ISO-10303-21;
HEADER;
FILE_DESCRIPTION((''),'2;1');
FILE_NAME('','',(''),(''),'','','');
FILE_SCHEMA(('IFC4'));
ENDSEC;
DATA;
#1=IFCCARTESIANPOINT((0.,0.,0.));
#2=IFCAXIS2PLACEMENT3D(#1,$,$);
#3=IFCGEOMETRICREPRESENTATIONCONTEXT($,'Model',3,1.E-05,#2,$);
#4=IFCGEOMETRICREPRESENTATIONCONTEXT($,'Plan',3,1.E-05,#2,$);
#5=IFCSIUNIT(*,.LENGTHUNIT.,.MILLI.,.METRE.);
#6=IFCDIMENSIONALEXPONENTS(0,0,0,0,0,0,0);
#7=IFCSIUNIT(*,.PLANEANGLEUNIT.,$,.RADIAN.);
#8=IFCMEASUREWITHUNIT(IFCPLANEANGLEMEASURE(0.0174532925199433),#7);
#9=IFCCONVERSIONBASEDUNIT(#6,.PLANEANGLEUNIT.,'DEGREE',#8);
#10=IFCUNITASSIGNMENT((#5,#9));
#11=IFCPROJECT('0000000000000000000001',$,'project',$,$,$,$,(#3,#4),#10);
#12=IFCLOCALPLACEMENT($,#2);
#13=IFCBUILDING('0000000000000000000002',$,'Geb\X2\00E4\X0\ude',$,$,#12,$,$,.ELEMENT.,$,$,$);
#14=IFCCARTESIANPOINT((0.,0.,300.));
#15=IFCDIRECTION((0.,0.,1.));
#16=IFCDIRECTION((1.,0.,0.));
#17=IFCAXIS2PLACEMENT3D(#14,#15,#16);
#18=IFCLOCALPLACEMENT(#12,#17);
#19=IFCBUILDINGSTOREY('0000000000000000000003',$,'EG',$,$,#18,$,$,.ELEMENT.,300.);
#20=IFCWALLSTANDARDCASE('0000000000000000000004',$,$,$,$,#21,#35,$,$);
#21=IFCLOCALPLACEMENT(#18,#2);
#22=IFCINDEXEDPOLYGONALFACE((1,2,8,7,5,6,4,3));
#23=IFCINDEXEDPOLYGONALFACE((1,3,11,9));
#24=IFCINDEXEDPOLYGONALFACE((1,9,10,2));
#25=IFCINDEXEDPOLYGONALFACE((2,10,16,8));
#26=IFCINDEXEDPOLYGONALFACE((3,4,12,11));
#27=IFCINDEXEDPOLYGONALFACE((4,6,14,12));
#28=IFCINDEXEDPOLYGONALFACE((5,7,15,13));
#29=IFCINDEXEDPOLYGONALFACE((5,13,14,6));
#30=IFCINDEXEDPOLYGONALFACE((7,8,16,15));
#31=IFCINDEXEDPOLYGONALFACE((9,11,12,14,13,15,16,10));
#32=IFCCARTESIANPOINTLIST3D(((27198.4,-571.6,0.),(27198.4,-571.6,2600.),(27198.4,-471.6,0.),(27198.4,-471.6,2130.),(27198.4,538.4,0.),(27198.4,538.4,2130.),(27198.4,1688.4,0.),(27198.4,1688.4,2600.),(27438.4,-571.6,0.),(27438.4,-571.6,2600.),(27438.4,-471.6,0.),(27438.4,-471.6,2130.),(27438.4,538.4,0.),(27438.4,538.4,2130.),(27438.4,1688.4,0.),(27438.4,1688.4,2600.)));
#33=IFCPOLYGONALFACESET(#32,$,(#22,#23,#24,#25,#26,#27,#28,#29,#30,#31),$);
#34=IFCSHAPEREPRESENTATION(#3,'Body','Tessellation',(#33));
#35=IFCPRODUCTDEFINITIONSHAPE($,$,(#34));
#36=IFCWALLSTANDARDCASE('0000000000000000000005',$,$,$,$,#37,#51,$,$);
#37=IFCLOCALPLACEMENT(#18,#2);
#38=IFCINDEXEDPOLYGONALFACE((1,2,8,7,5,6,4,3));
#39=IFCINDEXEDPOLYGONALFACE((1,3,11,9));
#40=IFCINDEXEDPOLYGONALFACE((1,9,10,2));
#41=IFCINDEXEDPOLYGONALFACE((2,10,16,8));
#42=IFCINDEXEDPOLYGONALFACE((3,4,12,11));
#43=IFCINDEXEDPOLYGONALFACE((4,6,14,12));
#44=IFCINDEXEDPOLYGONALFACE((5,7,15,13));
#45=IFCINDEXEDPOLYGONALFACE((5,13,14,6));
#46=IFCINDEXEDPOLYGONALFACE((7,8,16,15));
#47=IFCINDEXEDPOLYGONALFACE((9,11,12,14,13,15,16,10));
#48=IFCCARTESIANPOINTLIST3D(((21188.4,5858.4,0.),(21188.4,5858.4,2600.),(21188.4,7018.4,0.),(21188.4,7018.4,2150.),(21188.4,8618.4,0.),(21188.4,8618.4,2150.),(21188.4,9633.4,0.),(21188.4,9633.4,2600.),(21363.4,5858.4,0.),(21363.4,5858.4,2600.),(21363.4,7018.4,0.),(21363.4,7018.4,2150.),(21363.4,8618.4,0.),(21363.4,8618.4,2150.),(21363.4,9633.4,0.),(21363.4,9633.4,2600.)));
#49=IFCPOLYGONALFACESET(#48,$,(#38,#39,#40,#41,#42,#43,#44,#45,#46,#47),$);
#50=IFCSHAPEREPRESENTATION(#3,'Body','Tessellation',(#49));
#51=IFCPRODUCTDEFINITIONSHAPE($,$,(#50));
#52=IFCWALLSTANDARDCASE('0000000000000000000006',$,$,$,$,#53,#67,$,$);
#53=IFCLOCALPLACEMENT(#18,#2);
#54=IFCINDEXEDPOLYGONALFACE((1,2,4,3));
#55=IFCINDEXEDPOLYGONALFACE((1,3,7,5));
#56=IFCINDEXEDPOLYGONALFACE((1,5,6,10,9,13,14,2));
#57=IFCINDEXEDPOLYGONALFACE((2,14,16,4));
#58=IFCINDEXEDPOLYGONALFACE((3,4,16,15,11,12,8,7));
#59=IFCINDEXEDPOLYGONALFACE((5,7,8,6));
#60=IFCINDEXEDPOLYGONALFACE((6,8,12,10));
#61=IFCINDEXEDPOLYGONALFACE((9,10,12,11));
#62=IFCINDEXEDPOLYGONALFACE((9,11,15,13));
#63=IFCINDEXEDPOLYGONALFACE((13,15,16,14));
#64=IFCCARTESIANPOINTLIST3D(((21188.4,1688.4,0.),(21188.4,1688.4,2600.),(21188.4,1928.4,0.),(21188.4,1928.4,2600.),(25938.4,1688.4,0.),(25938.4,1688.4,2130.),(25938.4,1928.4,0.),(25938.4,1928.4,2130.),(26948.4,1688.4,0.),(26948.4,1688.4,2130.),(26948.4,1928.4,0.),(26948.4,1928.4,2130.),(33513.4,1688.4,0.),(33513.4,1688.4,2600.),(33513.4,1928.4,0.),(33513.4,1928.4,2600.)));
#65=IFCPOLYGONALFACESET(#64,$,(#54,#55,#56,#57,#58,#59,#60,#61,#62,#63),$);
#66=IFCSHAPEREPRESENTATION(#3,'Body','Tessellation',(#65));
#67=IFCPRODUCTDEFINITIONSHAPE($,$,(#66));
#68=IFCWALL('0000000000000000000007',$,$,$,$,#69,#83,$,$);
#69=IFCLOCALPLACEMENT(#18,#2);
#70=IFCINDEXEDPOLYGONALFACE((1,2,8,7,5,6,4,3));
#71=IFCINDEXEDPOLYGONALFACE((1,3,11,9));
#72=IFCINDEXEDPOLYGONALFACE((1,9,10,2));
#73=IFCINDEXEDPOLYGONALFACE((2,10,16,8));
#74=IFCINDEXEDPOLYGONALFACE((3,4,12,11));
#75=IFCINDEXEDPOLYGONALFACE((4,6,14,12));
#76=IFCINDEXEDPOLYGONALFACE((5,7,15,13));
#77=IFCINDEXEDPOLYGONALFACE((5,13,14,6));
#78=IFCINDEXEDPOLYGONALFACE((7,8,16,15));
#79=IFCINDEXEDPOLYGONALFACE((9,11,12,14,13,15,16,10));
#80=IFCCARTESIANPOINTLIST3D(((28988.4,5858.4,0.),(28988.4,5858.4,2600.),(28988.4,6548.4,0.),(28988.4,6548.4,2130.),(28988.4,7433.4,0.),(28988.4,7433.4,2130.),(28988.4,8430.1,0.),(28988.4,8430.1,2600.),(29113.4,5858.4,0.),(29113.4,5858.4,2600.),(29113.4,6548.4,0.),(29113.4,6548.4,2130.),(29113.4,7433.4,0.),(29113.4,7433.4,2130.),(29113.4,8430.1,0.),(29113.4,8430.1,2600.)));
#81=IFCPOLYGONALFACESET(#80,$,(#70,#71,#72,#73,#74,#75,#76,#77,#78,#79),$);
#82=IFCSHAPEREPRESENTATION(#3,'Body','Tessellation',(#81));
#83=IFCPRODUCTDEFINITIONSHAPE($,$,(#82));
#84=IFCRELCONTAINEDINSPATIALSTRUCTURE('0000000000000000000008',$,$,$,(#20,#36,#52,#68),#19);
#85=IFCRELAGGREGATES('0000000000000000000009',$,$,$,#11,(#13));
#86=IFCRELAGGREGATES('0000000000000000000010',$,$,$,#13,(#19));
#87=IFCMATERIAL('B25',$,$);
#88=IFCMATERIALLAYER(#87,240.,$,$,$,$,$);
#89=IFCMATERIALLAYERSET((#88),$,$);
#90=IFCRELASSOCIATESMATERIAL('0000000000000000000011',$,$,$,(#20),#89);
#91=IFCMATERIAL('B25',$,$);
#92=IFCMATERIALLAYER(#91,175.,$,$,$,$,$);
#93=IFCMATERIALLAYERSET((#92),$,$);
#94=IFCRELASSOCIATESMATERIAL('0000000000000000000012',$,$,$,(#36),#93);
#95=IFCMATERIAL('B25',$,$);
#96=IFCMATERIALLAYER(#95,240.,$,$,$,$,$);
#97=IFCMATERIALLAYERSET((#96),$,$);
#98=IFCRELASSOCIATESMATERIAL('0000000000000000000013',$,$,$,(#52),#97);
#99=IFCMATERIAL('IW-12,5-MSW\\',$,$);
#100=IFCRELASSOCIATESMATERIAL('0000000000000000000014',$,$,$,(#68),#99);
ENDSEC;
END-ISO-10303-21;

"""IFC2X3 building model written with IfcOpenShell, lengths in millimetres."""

from ifc_helpers import new_model, entity, si_unit, converted_unit, frame, frame_2d, origin, origin_with_axes, place, context, project, spatial, polyline, rectangle, outline, extrude, material, layer, layer_set, layer_usage, element, save


model = new_model("IFC2X3")

# Units and contexts
model_context = context("Model", 3, precision=1e-05, world=origin())
plan_context = context("Plan", 3, precision=1e-05, world=origin())
ifc_project = project(units=[si_unit("LENGTHUNIT", "METRE", prefix="MILLI"), converted_unit("PLANEANGLEUNIT", "DEGREE", entity("IfcPlaneAngleMeasure", 0.0174532925199433), si_unit("PLANEANGLEUNIT", "RADIAN"), dimensions=[0, 0, 0, 0, 0, 0, 0])], contexts=[model_context, plan_context])

# Building, storey
building_placement = place(None, origin())
building = spatial("IfcBuilding", under=ifc_project, at=building_placement, Name="Gebäude", CompositionType="ELEMENT")
storey_placement = place(building_placement, frame((0.0, 0.0, 300.0), z_axis=(0.0, 0.0, 1.0), x_axis=(1.0, 0.0, 0.0)))
storey = spatial("IfcBuildingStorey", under=building, at=storey_placement, Name="EG", CompositionType="ELEMENT", Elevation=300.0)

# Walls, openings
ifc_material_1 = material(Name="B25")
ifc_layer_1 = layer(ifc_material_1, 240.0)
ifc_layer_set_1 = layer_set([ifc_layer_1])
ifc_layer_usage_1 = layer_usage(ifc_layer_set_1, "AXIS2", "POSITIVE", 0.0)
wall_1_placement = place(storey_placement, frame((27198.4, 1688.4, 0.0), z_axis=(0.0, 0.0, 1.0), x_axis=(0.0, -1.0, 0.0)))
wall_1 = element("IfcWallStandardCase", 1, at=wall_1_placement, inside=storey, material=ifc_layer_usage_1, context=model_context, shape_type="SweptSolid", body=[
    extrude(rectangle(XDim=2260.0, YDim=240.0, at=frame_2d((1130.0, 120.0), x_axis=(1.0, 0.0))), origin_with_axes(), (0.0, 0.0, 1.0), 2600.0),
])
opening_1_placement = place(wall_1_placement, frame((1150.0, 0.0, 0.0), z_axis=(0.0, 1.0, 0.0), x_axis=(0.0, 0.0, 1.0)))
element("IfcOpeningElement", 2, at=opening_1_placement, cuts=wall_1, ObjectType="Opening", context=model_context, shape_type="SweptSolid", body=[
    extrude(rectangle(XDim=2130.0, YDim=1010.0, at=frame_2d((1065.0, 505.0), x_axis=(1.0, 0.0))), origin_with_axes(), (0.0, 0.0, 1.0), 240.0),
])
ifc_material_2 = material(Name="B25")
ifc_layer_2 = layer(ifc_material_2, 175.0)
ifc_layer_set_2 = layer_set([ifc_layer_2])
ifc_layer_usage_2 = layer_usage(ifc_layer_set_2, "AXIS2", "POSITIVE", 0.0)
wall_2_placement = place(storey_placement, frame((21188.4, 9633.4, 0.0), z_axis=(0.0, 0.0, 1.0), x_axis=(0.0, -1.0, 0.0)))
wall_2 = element("IfcWallStandardCase", 3, at=wall_2_placement, inside=storey, material=ifc_layer_usage_2, context=model_context, shape_type="SweptSolid", body=[
    extrude(rectangle(XDim=3775.0, YDim=175.0, at=frame_2d((1887.5, 87.5), x_axis=(1.0, 0.0))), origin_with_axes(), (0.0, 0.0, 1.0), 2600.0),
])
opening_2_placement = place(wall_2_placement, frame((1015.0, 0.0, 0.0), z_axis=(0.0, 1.0, 0.0), x_axis=(0.0, 0.0, 1.0)))
element("IfcOpeningElement", 4, at=opening_2_placement, cuts=wall_2, ObjectType="Opening", context=model_context, shape_type="SweptSolid", body=[
    extrude(rectangle(XDim=2150.0, YDim=1600.0, at=frame_2d((1075.0, 800.0), x_axis=(1.0, 0.0))), origin_with_axes(), (0.0, 0.0, 1.0), 175.0),
])
ifc_material_3 = material(Name="B25")
ifc_layer_3 = layer(ifc_material_3, 240.0)
ifc_layer_set_3 = layer_set([ifc_layer_3])
ifc_layer_usage_3 = layer_usage(ifc_layer_set_3, "AXIS2", "POSITIVE", 0.0)
wall_3_placement = place(storey_placement, frame((33513.4, 1928.4, 0.0), z_axis=(0.0, 0.0, 1.0), x_axis=(-1.0, 0.0, 0.0)))
wall_3 = element("IfcWallStandardCase", 5, at=wall_3_placement, inside=storey, material=ifc_layer_usage_3, context=model_context, shape_type="SweptSolid", body=[
    extrude(rectangle(XDim=12325.0, YDim=240.0, at=frame_2d((6162.5, 120.0), x_axis=(1.0, 0.0))), origin_with_axes(), (0.0, 0.0, 1.0), 2600.0),
])
opening_3_placement = place(wall_3_placement, frame((6565.0, 0.0, 0.0), z_axis=(0.0, 1.0, 0.0), x_axis=(0.0, 0.0, 1.0)))
element("IfcOpeningElement", 6, at=opening_3_placement, cuts=wall_3, ObjectType="Opening", context=model_context, shape_type="SweptSolid", body=[
    extrude(rectangle(XDim=2130.0, YDim=1010.0, at=frame_2d((1065.0, 505.0), x_axis=(1.0, 0.0))), origin_with_axes(), (0.0, 0.0, 1.0), 240.0),
])
ifc_material_4 = material(Name="IW-12,5-MSW\\")
wall_4_placement = place(storey_placement, frame((29113.4, 5858.4, 0.0), z_axis=(0.0, 0.0, 1.0), x_axis=(0.0, 1.0, 0.0)))
wall_4 = element("IfcWall", 7, at=wall_4_placement, inside=storey, material=ifc_material_4, context=model_context, shape_type="SweptSolid", body=[
    extrude(outline(polyline([(2571.7, 125.0), (0.0, 125.0), (0.0, 0.0), (2571.7, 0.0), (2571.7, 125.0)])), origin_with_axes(), (0.0, 0.0, 1.0), 2600.0),
])
opening_4_placement = place(wall_4_placement, frame((690.0, 0.0, 0.0), z_axis=(0.0, 1.0, 0.0), x_axis=(0.0, 0.0, 1.0)))
element("IfcOpeningElement", 8, at=opening_4_placement, cuts=wall_4, ObjectType="Opening", context=model_context, shape_type="SweptSolid", body=[
    extrude(rectangle(XDim=2130.0, YDim=885.0, at=frame_2d((1065.0, 442.5), x_axis=(1.0, 0.0))), origin_with_axes(), (0.0, 0.0, 1.0), 125.0),
])

save(model, "model.ifc")
